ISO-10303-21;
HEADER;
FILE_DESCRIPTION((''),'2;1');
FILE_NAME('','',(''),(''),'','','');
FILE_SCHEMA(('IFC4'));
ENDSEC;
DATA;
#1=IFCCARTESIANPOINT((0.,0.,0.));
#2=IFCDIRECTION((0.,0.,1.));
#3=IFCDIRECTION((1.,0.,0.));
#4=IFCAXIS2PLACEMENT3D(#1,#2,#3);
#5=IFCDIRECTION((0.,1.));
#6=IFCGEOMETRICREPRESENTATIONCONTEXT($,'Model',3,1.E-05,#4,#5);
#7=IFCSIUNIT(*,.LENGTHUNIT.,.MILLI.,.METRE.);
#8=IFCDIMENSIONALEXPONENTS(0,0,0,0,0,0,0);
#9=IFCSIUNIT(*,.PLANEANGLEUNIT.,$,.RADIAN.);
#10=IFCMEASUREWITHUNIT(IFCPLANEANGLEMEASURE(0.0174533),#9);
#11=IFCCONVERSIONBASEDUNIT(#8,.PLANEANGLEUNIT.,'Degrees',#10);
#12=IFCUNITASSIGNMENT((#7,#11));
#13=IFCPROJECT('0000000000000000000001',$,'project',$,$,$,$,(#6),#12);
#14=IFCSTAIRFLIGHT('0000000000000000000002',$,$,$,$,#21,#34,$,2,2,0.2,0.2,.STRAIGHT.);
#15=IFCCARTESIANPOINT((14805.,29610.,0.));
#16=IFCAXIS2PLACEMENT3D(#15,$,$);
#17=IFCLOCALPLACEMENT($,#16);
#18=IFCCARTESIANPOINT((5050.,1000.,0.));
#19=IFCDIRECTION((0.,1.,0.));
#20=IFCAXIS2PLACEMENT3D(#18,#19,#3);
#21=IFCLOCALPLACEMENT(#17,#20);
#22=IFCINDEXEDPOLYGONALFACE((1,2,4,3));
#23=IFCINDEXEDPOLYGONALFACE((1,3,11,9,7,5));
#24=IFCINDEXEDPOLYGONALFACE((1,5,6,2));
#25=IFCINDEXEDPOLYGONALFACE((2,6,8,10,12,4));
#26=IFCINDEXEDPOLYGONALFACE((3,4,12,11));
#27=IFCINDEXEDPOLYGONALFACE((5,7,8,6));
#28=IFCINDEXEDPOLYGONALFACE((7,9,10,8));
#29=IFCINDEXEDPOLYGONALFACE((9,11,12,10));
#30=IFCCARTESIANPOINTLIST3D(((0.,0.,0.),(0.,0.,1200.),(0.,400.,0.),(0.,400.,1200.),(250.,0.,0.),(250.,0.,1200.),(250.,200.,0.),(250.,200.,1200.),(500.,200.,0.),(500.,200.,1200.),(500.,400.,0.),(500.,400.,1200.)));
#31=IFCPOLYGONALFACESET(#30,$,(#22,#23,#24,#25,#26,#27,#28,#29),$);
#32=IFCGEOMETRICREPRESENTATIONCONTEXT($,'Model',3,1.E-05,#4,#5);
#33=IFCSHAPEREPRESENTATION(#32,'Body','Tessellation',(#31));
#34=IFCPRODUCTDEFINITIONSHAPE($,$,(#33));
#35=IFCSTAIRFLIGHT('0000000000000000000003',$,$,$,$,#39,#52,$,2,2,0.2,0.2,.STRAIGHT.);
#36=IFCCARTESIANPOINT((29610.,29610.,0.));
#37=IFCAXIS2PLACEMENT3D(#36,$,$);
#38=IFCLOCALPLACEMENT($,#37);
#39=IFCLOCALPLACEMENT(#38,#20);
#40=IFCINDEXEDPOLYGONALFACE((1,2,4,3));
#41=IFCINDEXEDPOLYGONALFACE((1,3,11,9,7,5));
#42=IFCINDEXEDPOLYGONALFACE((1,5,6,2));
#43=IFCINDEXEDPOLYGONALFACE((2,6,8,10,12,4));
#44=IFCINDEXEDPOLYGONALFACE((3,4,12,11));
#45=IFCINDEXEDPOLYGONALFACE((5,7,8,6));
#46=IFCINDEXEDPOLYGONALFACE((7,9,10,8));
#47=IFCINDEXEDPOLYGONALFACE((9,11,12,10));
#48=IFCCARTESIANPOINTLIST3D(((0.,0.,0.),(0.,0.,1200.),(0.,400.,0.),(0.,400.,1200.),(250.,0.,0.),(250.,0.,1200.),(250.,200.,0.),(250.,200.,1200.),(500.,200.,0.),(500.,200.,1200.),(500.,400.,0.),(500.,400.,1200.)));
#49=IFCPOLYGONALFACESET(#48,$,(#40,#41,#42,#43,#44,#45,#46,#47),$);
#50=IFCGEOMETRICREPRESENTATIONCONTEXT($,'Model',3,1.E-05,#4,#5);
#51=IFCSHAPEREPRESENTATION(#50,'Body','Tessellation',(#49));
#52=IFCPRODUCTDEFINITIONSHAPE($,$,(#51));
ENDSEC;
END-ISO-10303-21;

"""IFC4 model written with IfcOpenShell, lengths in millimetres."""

from ifc_helpers import new_model, entity, si_unit, converted_unit, direction, frame, origin_with_axes, place, context, project, polyline, outline, extrude, element, save


model = new_model("IFC4")

# Units and contexts
model_context_1 = context("Model", 3, precision=1e-05, world=origin_with_axes(), true_north=direction((0.0, 1.0)))
model_context_2 = context("Model", 3, precision=1e-05, world=origin_with_axes(), true_north=direction((0.0, 1.0)))
model_context_3 = context("Model", 3, precision=1e-05, world=origin_with_axes(), true_north=direction((0.0, 1.0)))
ifc_project = project(units=[si_unit("LENGTHUNIT", "METRE", prefix="MILLI"), converted_unit("PLANEANGLEUNIT", "Degrees", entity("IfcPlaneAngleMeasure", 0.0174533), si_unit("PLANEANGLEUNIT", "RADIAN"), dimensions=[0, 0, 0, 0, 0, 0, 0])], contexts=[model_context_1])

# Shared definitions
placement_1 = place(None, frame((29610.0, 29610.0, 0.0)))

# Shared definitions
placement_2 = place(None, frame((14805.0, 29610.0, 0.0)))

# Stair flights
stair_flight_1_placement = place(placement_2, frame((5050.0, 1000.0, 0.0), z_axis=(0.0, 1.0, 0.0), x_axis=(1.0, 0.0, 0.0)))
element("IfcStairFlight", 1, at=stair_flight_1_placement, NumberOfRisers=2, NumberOfTreads=2, PredefinedType="STRAIGHT", RiserHeight=0.2, TreadLength=0.2, context=model_context_2, shape_type="SweptSolid", body=[
    extrude(outline(polyline([(0.0, 0.0), (250.0, 0.0), (250.0, 200.0), (500.0, 200.0), (500.0, 400.0), (0.0, 400.0), (0.0, 0.0)])), origin_with_axes(), (0.0, 0.0, 1.0), 1200.0),
])
stair_flight_2_placement = place(placement_1, frame((5050.0, 1000.0, 0.0), z_axis=(0.0, 1.0, 0.0), x_axis=(1.0, 0.0, 0.0)))
element("IfcStairFlight", 2, at=stair_flight_2_placement, NumberOfRisers=2, NumberOfTreads=2, PredefinedType="STRAIGHT", RiserHeight=0.2, TreadLength=0.2, context=model_context_3, shape_type="SweptSolid", body=[
    extrude(outline(polyline([(0.0, 0.0), (250.0, 0.0), (250.0, 200.0), (500.0, 200.0), (500.0, 400.0), (0.0, 400.0), (0.0, 0.0)])), origin_with_axes(), (0.0, 0.0, 1.0), 1200.0),
])

save(model, "model.ifc")
